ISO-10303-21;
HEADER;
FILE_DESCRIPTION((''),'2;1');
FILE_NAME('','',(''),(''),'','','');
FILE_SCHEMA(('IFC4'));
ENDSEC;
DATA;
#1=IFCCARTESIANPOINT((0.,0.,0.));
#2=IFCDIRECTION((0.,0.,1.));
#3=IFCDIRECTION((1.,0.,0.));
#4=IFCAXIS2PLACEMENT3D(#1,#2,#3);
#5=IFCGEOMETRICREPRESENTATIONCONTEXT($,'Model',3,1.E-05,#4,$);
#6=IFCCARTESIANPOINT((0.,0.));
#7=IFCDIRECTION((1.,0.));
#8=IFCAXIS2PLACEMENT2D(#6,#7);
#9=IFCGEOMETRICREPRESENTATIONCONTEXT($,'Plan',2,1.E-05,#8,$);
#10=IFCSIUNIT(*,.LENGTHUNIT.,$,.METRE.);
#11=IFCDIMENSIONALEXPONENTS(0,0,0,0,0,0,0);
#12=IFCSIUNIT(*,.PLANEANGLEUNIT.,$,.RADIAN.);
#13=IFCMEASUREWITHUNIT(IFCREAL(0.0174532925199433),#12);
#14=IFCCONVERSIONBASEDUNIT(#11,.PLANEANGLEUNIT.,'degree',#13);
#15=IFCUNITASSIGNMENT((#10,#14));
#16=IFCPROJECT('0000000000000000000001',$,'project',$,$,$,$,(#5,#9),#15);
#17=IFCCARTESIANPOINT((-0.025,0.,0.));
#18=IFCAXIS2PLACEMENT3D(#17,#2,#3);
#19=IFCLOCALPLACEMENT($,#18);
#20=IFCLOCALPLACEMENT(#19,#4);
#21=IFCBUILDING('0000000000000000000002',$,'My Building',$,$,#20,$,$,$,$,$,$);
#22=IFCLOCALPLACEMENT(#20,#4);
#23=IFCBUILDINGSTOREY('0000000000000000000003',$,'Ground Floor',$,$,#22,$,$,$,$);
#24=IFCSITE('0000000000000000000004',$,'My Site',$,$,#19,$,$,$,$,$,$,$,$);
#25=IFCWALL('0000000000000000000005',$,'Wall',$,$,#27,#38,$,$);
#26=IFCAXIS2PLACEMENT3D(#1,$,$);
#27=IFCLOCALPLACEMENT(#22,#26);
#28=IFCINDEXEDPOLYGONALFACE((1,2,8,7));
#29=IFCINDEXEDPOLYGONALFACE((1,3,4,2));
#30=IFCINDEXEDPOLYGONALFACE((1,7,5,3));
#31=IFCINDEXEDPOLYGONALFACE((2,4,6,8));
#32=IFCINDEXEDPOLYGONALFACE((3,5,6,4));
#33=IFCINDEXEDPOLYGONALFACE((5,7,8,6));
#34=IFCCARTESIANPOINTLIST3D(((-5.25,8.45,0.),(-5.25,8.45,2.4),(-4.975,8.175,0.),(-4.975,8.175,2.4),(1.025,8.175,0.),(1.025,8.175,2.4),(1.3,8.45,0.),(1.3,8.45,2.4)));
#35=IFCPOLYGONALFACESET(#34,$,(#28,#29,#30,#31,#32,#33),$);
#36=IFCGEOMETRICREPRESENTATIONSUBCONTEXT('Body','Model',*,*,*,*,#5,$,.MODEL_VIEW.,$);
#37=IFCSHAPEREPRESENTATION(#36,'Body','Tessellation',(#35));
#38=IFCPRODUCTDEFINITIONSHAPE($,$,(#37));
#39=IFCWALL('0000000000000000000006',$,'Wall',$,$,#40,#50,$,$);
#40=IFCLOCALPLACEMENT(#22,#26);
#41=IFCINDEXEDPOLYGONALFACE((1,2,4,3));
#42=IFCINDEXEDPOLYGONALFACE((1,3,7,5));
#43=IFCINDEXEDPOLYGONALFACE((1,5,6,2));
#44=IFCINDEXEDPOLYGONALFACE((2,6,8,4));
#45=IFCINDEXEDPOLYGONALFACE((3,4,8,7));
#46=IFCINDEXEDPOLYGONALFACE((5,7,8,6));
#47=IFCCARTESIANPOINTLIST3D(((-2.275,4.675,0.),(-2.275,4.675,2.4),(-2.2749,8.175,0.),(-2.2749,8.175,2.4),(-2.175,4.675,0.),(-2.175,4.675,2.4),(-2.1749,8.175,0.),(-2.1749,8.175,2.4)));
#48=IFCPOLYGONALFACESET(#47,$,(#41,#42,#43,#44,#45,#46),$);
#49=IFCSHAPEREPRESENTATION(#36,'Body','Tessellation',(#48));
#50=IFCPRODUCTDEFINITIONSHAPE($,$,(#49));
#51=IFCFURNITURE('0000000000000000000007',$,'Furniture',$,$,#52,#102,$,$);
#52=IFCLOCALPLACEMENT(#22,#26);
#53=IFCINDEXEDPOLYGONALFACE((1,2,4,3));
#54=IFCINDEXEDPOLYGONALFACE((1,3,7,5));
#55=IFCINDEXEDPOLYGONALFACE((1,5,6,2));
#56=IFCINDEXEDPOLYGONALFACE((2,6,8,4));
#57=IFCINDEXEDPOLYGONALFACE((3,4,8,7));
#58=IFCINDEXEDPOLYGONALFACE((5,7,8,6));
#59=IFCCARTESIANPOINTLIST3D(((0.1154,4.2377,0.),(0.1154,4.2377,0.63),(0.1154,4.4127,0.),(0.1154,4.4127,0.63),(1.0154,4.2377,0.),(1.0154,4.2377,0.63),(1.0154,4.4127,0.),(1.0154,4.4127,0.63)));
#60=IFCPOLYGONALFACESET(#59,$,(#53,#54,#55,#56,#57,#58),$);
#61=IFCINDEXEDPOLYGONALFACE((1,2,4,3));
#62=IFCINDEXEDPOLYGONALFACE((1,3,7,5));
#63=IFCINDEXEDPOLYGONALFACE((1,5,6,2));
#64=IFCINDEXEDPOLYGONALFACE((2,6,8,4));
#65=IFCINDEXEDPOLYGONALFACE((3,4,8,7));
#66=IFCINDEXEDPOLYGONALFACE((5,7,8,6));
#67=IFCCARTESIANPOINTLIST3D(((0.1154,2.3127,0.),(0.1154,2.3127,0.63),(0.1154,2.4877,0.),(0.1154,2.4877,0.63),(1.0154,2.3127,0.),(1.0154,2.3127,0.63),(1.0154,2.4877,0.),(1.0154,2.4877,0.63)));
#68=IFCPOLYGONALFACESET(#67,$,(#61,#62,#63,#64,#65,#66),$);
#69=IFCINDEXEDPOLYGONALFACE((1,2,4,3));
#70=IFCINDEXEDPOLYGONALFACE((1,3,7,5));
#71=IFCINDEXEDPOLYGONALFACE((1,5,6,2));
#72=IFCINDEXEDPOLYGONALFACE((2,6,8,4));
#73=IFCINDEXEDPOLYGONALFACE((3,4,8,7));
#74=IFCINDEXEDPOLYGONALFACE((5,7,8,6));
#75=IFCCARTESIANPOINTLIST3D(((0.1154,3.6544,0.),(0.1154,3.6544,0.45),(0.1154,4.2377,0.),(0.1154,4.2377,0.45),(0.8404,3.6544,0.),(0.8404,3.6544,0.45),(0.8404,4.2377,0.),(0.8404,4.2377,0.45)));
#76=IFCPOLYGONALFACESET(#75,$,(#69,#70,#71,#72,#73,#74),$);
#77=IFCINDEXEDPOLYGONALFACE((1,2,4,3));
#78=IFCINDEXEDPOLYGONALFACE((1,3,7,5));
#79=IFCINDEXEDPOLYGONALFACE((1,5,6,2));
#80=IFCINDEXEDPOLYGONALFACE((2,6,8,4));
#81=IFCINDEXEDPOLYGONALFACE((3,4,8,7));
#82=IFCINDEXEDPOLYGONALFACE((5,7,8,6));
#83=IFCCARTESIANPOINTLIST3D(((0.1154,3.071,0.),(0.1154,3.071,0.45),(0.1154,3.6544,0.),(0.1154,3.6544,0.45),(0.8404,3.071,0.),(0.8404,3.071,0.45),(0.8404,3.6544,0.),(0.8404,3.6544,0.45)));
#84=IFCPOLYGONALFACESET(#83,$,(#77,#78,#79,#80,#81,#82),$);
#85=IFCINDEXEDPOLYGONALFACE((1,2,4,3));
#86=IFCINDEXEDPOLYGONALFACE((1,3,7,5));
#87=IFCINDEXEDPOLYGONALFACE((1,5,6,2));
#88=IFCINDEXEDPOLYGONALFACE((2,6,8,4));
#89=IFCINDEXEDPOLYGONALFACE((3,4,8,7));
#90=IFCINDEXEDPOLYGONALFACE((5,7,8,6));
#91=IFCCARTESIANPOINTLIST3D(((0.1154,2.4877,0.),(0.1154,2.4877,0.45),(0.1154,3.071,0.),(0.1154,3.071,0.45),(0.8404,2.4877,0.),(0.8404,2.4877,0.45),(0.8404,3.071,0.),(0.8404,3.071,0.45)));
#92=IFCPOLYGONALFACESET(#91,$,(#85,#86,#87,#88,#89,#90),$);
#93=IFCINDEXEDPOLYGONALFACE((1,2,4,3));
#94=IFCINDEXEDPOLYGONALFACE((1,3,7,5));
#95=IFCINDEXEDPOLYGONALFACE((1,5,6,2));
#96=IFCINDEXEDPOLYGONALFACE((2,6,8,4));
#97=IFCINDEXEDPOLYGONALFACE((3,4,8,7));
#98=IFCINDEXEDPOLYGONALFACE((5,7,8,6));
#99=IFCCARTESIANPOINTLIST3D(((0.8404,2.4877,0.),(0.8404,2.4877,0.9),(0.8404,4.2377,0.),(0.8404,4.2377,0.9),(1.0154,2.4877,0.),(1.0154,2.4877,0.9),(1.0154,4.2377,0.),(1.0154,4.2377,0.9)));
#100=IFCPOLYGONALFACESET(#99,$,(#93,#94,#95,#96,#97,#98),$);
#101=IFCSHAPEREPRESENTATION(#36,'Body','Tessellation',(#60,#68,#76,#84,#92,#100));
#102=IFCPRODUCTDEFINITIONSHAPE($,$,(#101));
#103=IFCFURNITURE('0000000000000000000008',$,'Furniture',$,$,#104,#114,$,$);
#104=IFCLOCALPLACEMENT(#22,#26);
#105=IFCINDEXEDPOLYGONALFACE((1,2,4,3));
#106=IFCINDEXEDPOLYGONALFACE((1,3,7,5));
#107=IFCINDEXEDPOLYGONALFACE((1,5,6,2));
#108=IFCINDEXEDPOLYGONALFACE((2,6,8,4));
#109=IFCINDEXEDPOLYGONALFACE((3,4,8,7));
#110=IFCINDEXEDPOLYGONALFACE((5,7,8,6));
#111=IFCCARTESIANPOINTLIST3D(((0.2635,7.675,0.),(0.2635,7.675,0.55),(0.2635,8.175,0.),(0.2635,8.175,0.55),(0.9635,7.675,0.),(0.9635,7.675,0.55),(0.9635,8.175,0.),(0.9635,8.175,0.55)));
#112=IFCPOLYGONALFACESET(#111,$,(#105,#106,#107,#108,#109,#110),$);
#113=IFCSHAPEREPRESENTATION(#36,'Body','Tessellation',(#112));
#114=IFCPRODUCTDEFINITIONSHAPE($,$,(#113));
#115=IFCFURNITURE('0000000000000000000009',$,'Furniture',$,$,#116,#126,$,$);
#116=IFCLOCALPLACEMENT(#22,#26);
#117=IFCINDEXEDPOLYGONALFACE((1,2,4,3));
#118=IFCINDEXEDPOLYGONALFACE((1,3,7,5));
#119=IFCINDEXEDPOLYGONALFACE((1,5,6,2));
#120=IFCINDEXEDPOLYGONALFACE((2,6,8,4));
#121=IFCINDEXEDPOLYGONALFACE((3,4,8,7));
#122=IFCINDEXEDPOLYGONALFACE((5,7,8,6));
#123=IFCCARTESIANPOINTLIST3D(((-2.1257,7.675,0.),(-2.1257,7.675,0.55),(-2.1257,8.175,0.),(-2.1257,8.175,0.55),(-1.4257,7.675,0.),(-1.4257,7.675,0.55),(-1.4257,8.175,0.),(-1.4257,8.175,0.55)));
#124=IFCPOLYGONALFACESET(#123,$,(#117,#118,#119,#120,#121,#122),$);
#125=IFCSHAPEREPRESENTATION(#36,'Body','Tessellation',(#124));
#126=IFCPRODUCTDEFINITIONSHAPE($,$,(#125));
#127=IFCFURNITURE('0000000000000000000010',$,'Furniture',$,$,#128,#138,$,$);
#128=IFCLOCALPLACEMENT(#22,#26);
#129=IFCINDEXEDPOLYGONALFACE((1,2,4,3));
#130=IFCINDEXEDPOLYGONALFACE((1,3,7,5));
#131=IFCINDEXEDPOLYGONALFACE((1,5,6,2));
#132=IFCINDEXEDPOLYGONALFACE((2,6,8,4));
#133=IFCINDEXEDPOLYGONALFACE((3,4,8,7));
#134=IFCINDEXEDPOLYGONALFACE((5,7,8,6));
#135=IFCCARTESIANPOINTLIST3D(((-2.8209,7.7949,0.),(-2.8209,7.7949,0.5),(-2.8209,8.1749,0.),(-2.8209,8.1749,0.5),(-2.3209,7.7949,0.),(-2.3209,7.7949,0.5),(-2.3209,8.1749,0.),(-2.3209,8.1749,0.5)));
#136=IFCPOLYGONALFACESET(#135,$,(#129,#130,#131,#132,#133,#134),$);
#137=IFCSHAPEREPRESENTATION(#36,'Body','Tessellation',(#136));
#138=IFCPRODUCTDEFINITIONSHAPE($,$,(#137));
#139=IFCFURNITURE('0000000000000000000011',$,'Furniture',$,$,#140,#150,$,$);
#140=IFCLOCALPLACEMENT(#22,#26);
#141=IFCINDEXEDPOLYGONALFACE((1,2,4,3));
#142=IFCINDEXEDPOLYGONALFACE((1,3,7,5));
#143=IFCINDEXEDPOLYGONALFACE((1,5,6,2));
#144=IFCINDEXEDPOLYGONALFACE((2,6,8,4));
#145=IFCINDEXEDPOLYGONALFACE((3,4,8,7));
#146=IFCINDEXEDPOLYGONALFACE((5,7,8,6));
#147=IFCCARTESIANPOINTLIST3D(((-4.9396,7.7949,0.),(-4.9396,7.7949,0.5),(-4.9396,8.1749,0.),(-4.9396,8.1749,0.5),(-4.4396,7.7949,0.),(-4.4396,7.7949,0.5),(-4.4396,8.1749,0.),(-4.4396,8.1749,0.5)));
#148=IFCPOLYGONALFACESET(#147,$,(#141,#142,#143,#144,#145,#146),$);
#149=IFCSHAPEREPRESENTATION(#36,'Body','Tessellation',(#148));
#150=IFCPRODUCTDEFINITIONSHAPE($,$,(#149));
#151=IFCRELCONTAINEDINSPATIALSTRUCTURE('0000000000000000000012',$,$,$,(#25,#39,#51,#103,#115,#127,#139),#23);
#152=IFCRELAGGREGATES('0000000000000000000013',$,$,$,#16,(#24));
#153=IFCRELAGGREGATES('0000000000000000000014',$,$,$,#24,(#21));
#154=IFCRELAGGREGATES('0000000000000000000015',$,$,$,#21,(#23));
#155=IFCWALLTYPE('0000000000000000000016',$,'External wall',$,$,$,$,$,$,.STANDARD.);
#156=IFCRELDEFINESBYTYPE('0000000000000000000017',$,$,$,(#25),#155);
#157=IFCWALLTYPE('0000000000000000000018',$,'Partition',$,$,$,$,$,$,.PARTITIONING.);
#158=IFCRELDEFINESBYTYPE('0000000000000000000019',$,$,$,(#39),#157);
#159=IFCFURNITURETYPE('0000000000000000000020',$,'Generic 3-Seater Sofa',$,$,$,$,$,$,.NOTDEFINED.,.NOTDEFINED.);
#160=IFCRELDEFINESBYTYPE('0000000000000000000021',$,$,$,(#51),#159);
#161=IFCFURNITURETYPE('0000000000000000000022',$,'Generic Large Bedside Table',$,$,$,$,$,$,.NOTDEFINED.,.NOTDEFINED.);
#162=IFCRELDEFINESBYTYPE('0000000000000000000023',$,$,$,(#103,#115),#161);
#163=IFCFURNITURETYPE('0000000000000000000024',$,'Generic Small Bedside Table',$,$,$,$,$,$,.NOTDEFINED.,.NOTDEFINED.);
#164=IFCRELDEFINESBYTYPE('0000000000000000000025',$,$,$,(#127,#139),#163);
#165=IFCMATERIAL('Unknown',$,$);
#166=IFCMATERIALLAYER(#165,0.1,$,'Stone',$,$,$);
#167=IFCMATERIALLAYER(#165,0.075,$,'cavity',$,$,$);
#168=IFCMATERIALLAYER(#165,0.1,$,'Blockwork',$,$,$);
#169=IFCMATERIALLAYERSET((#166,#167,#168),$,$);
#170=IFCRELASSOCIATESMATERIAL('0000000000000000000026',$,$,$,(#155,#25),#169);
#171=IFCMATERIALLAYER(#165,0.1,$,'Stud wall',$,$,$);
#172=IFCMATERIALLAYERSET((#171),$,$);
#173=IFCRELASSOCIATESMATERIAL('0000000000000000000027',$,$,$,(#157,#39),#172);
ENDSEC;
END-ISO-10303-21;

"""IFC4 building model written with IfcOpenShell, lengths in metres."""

from ifc_helpers import new_model, entity, si_unit, converted_unit, frame, origin_with_axes, origin_2d_with_axis, place, context, subcontext, project, spatial, line, indexed_curve, outline, extrude, clip, halfspace, shape, source, transform, mapped, material, layer, layer_set, layer_usage, type_object, type_shapes, element, save


model = new_model("IFC4")

# Units and contexts
model_context = context("Model", 3, precision=1e-05, world=origin_with_axes())
plan_context = context("Plan", 2, precision=1e-05, world=origin_2d_with_axis())
body_context_1 = subcontext(model_context, "Body", "Model", "MODEL_VIEW")
body_context_2 = subcontext(plan_context, "Body", "Plan", "PLAN_VIEW")
ifc_project = project(units=[si_unit("LENGTHUNIT", "METRE"), converted_unit("PLANEANGLEUNIT", "degree", entity("IfcReal", 0.0174532925199433), si_unit("PLANEANGLEUNIT", "RADIAN"), dimensions=[0, 0, 0, 0, 0, 0, 0])], contexts=[model_context, plan_context])

# Site, building, storey
site_placement = place(None, frame((-0.025, 0.0, 0.0), z_axis=(0.0, 0.0, 1.0), x_axis=(1.0, 0.0, 0.0)))
site = spatial("IfcSite", under=ifc_project, at=site_placement, Name="My Site")
building_placement = place(site_placement, origin_with_axes())
building = spatial("IfcBuilding", under=site, at=building_placement, Name="My Building")
storey_placement = place(building_placement, frame((0.0, 0.0, 0.0), z_axis=(0.0, 0.0, 1.0), x_axis=(1.0, 0.0, 0.0)))
storey = spatial("IfcBuildingStorey", under=building, at=storey_placement, Name="Ground Floor")

# Wall
ifc_material = material(Name="Unknown")
ifc_layer_1 = layer(ifc_material, 0.1, Name="Stone")
ifc_layer_2 = layer(ifc_material, 0.075, Name="cavity")
ifc_layer_3 = layer(ifc_material, 0.1, Name="Blockwork")
ifc_layer_set_1 = layer_set([ifc_layer_1, ifc_layer_2, ifc_layer_3])
ifc_layer_usage_1 = layer_usage(ifc_layer_set_1, "AXIS2", "POSITIVE", 0.0)
wall_type_1 = type_object("IfcWallType", Name="External wall", PredefinedType="STANDARD", material=ifc_layer_set_1)
wall_1_placement = place(storey_placement, frame((1.3, 8.45, 0.0), z_axis=(0.0, 0.0, 1.0), x_axis=(-1.0, 0.0, 0.0)))
element("IfcWall", 1, at=wall_1_placement, inside=storey, type_object=wall_type_1, material=ifc_layer_usage_1, Name="Wall", context=body_context_1, shape_type="Clipping", body=[
    clip(clip(extrude(outline(indexed_curve([(0.0, 0.0), (0.0, 0.275), (6.55, 0.275), (6.55, 0.0), (0.0, 0.0)], self_intersect=False)), origin_with_axes(), (0.0, 0.0, 1.0), 2.4), halfspace(frame((6.55, 0.0, 0.0), z_axis=(0.707106, 0.707107, 0.0), x_axis=(-0.707107, 0.707106, 0.0)), False)), halfspace(frame((0.0, 0.0, 0.0), z_axis=(-0.707106, 0.707107, 0.0), x_axis=(0.707107, 0.707106, 0.0)), False)),
])

# Shared definitions
ifc_layer_4 = layer(ifc_material, 0.1, Name="Stud wall")
ifc_layer_set_2 = layer_set([ifc_layer_4])
wall_type_2 = type_object("IfcWallType", Name="Partition", PredefinedType="PARTITIONING", material=ifc_layer_set_2)

# Wall
ifc_layer_usage_2 = layer_usage(ifc_layer_set_2, "AXIS2", "POSITIVE", 0.0)
wall_2_placement = place(storey_placement, frame((-2.175, 4.675, 0.0), z_axis=(0.0, 0.0, 1.0), x_axis=(0.0, 1.0, 0.0)))
element("IfcWall", 2, at=wall_2_placement, inside=storey, type_object=wall_type_2, material=ifc_layer_usage_2, Name="Wall", context=body_context_1, shape_type="SweptSolid", body=[
    extrude(outline(indexed_curve([(0.0, 0.0), (0.0, 0.1), (3.5, 0.1), (3.5, 0.0), (0.0, 0.0)], self_intersect=False)), origin_with_axes(), (0.0, 0.0, 1.0), 2.4),
])

# Furniture
furniture_type_1 = type_object("IfcFurnitureType", Name="Generic 3-Seater Sofa", AssemblyPlace="NOTDEFINED", PredefinedType="NOTDEFINED")
shared_shape_1 = source(origin_with_axes(), body_context_1, "Body", "SweptSolid", [
    extrude(outline(indexed_curve([(0.0, 0.0), (0.175, 0.0), (0.175, 0.9), (0.0, 0.9)], segments=[line(1, 2, 3, 4, 1)])), frame((-1.05, -0.9, 0.0), z_axis=(0.0, 0.0, 1.0), x_axis=(1.0, 0.0, 0.0)), (0.0, 0.0, 1.0), 0.63),
    extrude(outline(indexed_curve([(0.0, 0.0), (0.175, 0.0), (0.175, 0.9), (0.0, 0.9)], segments=[line(1, 2, 3, 4, 1)])), frame((0.875, -0.9, 0.0), z_axis=(0.0, 0.0, 1.0), x_axis=(1.0, 0.0, 0.0)), (0.0, 0.0, 1.0), 0.63),
    extrude(outline(indexed_curve([(0.175, 0.0), (0.7583, 0.0), (0.7583, 0.725), (0.175, 0.725)], segments=[line(1, 2, 3, 4, 1)])), frame((-1.05, -0.9, 0.0), z_axis=(0.0, 0.0, 1.0), x_axis=(1.0, 0.0, 0.0)), (0.0, 0.0, 1.0), 0.45),
    extrude(outline(indexed_curve([(0.7583, 0.0), (1.3417, 0.0), (1.3417, 0.725), (0.7583, 0.725)], segments=[line(1, 2, 3, 4, 1)])), frame((-1.05, -0.9, 0.0), z_axis=(0.0, 0.0, 1.0), x_axis=(1.0, 0.0, 0.0)), (0.0, 0.0, 1.0), 0.45),
    extrude(outline(indexed_curve([(1.3417, 0.0), (1.925, 0.0), (1.925, 0.725), (1.3417, 0.725)], segments=[line(1, 2, 3, 4, 1)])), frame((-1.05, -0.9, 0.0), z_axis=(0.0, 0.0, 1.0), x_axis=(1.0, 0.0, 0.0)), (0.0, 0.0, 1.0), 0.45),
    extrude(outline(indexed_curve([(0.175, 0.725), (1.925, 0.725), (1.925, 0.9), (0.175, 0.9)], segments=[line(1, 2, 3, 4, 1)])), frame((-1.05, -0.9, 0.0), z_axis=(0.0, 0.0, 1.0), x_axis=(1.0, 0.0, 0.0)), (0.0, 0.0, 1.0), 0.9),
])
shared_shape_2 = source(origin_with_axes(), body_context_2, "Body", "Curve2D", [
    entity("IfcIndexedPolyCurve", entity("IfcCartesianPointList2D", [[-1.05, -0.9], [-0.875, -0.9], [-0.875, 0.0], [-1.05, 0.0]]), [entity("IfcLineIndex", [1, 2, 3, 4, 1])]),
    entity("IfcIndexedPolyCurve", entity("IfcCartesianPointList2D", [[0.875, -0.9], [1.05, -0.9], [1.05, 0.0], [0.875, 0.0]]), [entity("IfcLineIndex", [1, 2, 3, 4, 1])]),
    entity("IfcIndexedPolyCurve", entity("IfcCartesianPointList2D", [[-0.875, -0.9], [-0.2917, -0.9], [-0.2917, -0.175], [-0.875, -0.175]]), [entity("IfcLineIndex", [1, 2, 3, 4, 1])]),
    entity("IfcIndexedPolyCurve", entity("IfcCartesianPointList2D", [[-0.2917, -0.9], [0.2917, -0.9], [0.2917, -0.175], [-0.2917, -0.175]]), [entity("IfcLineIndex", [1, 2, 3, 4, 1])]),
    entity("IfcIndexedPolyCurve", entity("IfcCartesianPointList2D", [[0.2917, -0.9], [0.875, -0.9], [0.875, -0.175], [0.2917, -0.175]]), [entity("IfcLineIndex", [1, 2, 3, 4, 1])]),
    entity("IfcIndexedPolyCurve", entity("IfcCartesianPointList2D", [[-0.875, -0.175], [0.875, -0.175], [0.875, 0.0], [-0.875, 0.0]]), [entity("IfcLineIndex", [1, 2, 3, 4, 1])]),
])
type_shapes(furniture_type_1, [shared_shape_1, shared_shape_2])
furniture_1_placement = place(storey_placement, frame((1.0154, 3.3627, 0.0), z_axis=(0.0, 0.0, 1.0), x_axis=(0.0, -1.0, 0.0)))
element("IfcFurniture", 3, at=furniture_1_placement, inside=storey, type_object=furniture_type_1, Name="Furniture", shapes=[
    shape(body_context_1, "Body", "MappedRepresentation", [mapped(shared_shape_1, transform((0.0, 0.0, 0.0), x_axis=(1.0, 0.0, 0.0), y_axis=(0.0, 1.0, 0.0), z_axis=(0.0, 0.0, 1.0), scale=1.0))]),
    shape(body_context_2, "Body", "MappedRepresentation", [mapped(shared_shape_2, transform((0.0, 0.0, 0.0), x_axis=(1.0, 0.0, 0.0), y_axis=(0.0, 1.0, 0.0), z_axis=(0.0, 0.0, 1.0), scale=1.0))]),
])
furniture_type_2 = type_object("IfcFurnitureType", Name="Generic Large Bedside Table", AssemblyPlace="NOTDEFINED", PredefinedType="NOTDEFINED")
shared_shape_3 = source(origin_with_axes(), body_context_1, "Body", "SweptSolid", [
    extrude(outline(indexed_curve([(0.0, 0.0), (0.7, 0.0), (0.7, 0.5), (0.0, 0.5)], segments=[line(1, 2, 3, 4, 1)])), frame((-0.35, -0.25, 0.0), z_axis=(0.0, 0.0, 1.0), x_axis=(1.0, 0.0, 0.0)), (0.0, 0.0, 1.0), 0.55),
])
shared_shape_4 = source(origin_with_axes(), body_context_2, "Body", "Curve2D", [
    entity("IfcIndexedPolyCurve", entity("IfcCartesianPointList2D", [[-0.35, -0.25], [0.35, -0.25], [0.35, 0.25], [-0.35, 0.25]]), [entity("IfcLineIndex", [1, 2, 3, 4, 1])]),
])
type_shapes(furniture_type_2, [shared_shape_3, shared_shape_4])
for number, where, z_axis, x_axis, name in (
    (4, (0.6135, 7.925, 0.0), (0.0, 0.0, 1.0), (1.0, 0.0, 0.0), "Furniture"),
    (5, (-1.7757, 7.925, 0.0), (0.0, 0.0, 1.0), (1.0, 0.0, 0.0), "Furniture"),
):
    element("IfcFurniture", number, at=place(storey_placement, frame(where, z_axis=z_axis, x_axis=x_axis)), inside=storey, type_object=furniture_type_2, Name=name, shapes=[
        shape(body_context_1, "Body", "MappedRepresentation", [mapped(shared_shape_3, transform((0.0, 0.0, 0.0), x_axis=(1.0, 0.0, 0.0), y_axis=(0.0, 1.0, 0.0), z_axis=(0.0, 0.0, 1.0), scale=1.0))]),
        shape(body_context_2, "Body", "MappedRepresentation", [mapped(shared_shape_4, transform((0.0, 0.0, 0.0), x_axis=(1.0, 0.0, 0.0), y_axis=(0.0, 1.0, 0.0), z_axis=(0.0, 0.0, 1.0), scale=1.0))]),
    ])
furniture_type_3 = type_object("IfcFurnitureType", Name="Generic Small Bedside Table", AssemblyPlace="NOTDEFINED", PredefinedType="NOTDEFINED")
shared_shape_5 = source(origin_with_axes(), body_context_1, "Body", "SweptSolid", [
    extrude(outline(indexed_curve([(0.0, 0.0), (0.5, 0.0), (0.5, 0.38), (0.0, 0.38)], segments=[line(1, 2, 3, 4, 1)])), frame((-0.25, -0.19, 0.0), z_axis=(0.0, 0.0, 1.0), x_axis=(1.0, 0.0, 0.0)), (0.0, 0.0, 1.0), 0.5),
])
shared_shape_6 = source(origin_with_axes(), body_context_2, "Body", "Curve2D", [
    entity("IfcIndexedPolyCurve", entity("IfcCartesianPointList2D", [[-0.25, -0.19], [0.25, -0.19], [0.25, 0.19], [-0.25, 0.19]]), [entity("IfcLineIndex", [1, 2, 3, 4, 1])]),
])
type_shapes(furniture_type_3, [shared_shape_5, shared_shape_6])
for number, where, z_axis, x_axis, name in (
    (6, (-2.5709, 7.9849, 0.0), (0.0, 0.0, 1.0), (1.0, 0.0, 0.0), "Furniture"),
    (7, (-4.6896, 7.9849, 0.0), (0.0, 0.0, 1.0), (1.0, 0.0, 0.0), "Furniture"),
):
    element("IfcFurniture", number, at=place(storey_placement, frame(where, z_axis=z_axis, x_axis=x_axis)), inside=storey, type_object=furniture_type_3, Name=name, shapes=[
        shape(body_context_1, "Body", "MappedRepresentation", [mapped(shared_shape_5, transform((0.0, 0.0, 0.0), x_axis=(1.0, 0.0, 0.0), y_axis=(0.0, 1.0, 0.0), z_axis=(0.0, 0.0, 1.0), scale=1.0))]),
        shape(body_context_2, "Body", "MappedRepresentation", [mapped(shared_shape_6, transform((0.0, 0.0, 0.0), x_axis=(1.0, 0.0, 0.0), y_axis=(0.0, 1.0, 0.0), z_axis=(0.0, 0.0, 1.0), scale=1.0))]),
    ])

save(model, "model.ifc")
